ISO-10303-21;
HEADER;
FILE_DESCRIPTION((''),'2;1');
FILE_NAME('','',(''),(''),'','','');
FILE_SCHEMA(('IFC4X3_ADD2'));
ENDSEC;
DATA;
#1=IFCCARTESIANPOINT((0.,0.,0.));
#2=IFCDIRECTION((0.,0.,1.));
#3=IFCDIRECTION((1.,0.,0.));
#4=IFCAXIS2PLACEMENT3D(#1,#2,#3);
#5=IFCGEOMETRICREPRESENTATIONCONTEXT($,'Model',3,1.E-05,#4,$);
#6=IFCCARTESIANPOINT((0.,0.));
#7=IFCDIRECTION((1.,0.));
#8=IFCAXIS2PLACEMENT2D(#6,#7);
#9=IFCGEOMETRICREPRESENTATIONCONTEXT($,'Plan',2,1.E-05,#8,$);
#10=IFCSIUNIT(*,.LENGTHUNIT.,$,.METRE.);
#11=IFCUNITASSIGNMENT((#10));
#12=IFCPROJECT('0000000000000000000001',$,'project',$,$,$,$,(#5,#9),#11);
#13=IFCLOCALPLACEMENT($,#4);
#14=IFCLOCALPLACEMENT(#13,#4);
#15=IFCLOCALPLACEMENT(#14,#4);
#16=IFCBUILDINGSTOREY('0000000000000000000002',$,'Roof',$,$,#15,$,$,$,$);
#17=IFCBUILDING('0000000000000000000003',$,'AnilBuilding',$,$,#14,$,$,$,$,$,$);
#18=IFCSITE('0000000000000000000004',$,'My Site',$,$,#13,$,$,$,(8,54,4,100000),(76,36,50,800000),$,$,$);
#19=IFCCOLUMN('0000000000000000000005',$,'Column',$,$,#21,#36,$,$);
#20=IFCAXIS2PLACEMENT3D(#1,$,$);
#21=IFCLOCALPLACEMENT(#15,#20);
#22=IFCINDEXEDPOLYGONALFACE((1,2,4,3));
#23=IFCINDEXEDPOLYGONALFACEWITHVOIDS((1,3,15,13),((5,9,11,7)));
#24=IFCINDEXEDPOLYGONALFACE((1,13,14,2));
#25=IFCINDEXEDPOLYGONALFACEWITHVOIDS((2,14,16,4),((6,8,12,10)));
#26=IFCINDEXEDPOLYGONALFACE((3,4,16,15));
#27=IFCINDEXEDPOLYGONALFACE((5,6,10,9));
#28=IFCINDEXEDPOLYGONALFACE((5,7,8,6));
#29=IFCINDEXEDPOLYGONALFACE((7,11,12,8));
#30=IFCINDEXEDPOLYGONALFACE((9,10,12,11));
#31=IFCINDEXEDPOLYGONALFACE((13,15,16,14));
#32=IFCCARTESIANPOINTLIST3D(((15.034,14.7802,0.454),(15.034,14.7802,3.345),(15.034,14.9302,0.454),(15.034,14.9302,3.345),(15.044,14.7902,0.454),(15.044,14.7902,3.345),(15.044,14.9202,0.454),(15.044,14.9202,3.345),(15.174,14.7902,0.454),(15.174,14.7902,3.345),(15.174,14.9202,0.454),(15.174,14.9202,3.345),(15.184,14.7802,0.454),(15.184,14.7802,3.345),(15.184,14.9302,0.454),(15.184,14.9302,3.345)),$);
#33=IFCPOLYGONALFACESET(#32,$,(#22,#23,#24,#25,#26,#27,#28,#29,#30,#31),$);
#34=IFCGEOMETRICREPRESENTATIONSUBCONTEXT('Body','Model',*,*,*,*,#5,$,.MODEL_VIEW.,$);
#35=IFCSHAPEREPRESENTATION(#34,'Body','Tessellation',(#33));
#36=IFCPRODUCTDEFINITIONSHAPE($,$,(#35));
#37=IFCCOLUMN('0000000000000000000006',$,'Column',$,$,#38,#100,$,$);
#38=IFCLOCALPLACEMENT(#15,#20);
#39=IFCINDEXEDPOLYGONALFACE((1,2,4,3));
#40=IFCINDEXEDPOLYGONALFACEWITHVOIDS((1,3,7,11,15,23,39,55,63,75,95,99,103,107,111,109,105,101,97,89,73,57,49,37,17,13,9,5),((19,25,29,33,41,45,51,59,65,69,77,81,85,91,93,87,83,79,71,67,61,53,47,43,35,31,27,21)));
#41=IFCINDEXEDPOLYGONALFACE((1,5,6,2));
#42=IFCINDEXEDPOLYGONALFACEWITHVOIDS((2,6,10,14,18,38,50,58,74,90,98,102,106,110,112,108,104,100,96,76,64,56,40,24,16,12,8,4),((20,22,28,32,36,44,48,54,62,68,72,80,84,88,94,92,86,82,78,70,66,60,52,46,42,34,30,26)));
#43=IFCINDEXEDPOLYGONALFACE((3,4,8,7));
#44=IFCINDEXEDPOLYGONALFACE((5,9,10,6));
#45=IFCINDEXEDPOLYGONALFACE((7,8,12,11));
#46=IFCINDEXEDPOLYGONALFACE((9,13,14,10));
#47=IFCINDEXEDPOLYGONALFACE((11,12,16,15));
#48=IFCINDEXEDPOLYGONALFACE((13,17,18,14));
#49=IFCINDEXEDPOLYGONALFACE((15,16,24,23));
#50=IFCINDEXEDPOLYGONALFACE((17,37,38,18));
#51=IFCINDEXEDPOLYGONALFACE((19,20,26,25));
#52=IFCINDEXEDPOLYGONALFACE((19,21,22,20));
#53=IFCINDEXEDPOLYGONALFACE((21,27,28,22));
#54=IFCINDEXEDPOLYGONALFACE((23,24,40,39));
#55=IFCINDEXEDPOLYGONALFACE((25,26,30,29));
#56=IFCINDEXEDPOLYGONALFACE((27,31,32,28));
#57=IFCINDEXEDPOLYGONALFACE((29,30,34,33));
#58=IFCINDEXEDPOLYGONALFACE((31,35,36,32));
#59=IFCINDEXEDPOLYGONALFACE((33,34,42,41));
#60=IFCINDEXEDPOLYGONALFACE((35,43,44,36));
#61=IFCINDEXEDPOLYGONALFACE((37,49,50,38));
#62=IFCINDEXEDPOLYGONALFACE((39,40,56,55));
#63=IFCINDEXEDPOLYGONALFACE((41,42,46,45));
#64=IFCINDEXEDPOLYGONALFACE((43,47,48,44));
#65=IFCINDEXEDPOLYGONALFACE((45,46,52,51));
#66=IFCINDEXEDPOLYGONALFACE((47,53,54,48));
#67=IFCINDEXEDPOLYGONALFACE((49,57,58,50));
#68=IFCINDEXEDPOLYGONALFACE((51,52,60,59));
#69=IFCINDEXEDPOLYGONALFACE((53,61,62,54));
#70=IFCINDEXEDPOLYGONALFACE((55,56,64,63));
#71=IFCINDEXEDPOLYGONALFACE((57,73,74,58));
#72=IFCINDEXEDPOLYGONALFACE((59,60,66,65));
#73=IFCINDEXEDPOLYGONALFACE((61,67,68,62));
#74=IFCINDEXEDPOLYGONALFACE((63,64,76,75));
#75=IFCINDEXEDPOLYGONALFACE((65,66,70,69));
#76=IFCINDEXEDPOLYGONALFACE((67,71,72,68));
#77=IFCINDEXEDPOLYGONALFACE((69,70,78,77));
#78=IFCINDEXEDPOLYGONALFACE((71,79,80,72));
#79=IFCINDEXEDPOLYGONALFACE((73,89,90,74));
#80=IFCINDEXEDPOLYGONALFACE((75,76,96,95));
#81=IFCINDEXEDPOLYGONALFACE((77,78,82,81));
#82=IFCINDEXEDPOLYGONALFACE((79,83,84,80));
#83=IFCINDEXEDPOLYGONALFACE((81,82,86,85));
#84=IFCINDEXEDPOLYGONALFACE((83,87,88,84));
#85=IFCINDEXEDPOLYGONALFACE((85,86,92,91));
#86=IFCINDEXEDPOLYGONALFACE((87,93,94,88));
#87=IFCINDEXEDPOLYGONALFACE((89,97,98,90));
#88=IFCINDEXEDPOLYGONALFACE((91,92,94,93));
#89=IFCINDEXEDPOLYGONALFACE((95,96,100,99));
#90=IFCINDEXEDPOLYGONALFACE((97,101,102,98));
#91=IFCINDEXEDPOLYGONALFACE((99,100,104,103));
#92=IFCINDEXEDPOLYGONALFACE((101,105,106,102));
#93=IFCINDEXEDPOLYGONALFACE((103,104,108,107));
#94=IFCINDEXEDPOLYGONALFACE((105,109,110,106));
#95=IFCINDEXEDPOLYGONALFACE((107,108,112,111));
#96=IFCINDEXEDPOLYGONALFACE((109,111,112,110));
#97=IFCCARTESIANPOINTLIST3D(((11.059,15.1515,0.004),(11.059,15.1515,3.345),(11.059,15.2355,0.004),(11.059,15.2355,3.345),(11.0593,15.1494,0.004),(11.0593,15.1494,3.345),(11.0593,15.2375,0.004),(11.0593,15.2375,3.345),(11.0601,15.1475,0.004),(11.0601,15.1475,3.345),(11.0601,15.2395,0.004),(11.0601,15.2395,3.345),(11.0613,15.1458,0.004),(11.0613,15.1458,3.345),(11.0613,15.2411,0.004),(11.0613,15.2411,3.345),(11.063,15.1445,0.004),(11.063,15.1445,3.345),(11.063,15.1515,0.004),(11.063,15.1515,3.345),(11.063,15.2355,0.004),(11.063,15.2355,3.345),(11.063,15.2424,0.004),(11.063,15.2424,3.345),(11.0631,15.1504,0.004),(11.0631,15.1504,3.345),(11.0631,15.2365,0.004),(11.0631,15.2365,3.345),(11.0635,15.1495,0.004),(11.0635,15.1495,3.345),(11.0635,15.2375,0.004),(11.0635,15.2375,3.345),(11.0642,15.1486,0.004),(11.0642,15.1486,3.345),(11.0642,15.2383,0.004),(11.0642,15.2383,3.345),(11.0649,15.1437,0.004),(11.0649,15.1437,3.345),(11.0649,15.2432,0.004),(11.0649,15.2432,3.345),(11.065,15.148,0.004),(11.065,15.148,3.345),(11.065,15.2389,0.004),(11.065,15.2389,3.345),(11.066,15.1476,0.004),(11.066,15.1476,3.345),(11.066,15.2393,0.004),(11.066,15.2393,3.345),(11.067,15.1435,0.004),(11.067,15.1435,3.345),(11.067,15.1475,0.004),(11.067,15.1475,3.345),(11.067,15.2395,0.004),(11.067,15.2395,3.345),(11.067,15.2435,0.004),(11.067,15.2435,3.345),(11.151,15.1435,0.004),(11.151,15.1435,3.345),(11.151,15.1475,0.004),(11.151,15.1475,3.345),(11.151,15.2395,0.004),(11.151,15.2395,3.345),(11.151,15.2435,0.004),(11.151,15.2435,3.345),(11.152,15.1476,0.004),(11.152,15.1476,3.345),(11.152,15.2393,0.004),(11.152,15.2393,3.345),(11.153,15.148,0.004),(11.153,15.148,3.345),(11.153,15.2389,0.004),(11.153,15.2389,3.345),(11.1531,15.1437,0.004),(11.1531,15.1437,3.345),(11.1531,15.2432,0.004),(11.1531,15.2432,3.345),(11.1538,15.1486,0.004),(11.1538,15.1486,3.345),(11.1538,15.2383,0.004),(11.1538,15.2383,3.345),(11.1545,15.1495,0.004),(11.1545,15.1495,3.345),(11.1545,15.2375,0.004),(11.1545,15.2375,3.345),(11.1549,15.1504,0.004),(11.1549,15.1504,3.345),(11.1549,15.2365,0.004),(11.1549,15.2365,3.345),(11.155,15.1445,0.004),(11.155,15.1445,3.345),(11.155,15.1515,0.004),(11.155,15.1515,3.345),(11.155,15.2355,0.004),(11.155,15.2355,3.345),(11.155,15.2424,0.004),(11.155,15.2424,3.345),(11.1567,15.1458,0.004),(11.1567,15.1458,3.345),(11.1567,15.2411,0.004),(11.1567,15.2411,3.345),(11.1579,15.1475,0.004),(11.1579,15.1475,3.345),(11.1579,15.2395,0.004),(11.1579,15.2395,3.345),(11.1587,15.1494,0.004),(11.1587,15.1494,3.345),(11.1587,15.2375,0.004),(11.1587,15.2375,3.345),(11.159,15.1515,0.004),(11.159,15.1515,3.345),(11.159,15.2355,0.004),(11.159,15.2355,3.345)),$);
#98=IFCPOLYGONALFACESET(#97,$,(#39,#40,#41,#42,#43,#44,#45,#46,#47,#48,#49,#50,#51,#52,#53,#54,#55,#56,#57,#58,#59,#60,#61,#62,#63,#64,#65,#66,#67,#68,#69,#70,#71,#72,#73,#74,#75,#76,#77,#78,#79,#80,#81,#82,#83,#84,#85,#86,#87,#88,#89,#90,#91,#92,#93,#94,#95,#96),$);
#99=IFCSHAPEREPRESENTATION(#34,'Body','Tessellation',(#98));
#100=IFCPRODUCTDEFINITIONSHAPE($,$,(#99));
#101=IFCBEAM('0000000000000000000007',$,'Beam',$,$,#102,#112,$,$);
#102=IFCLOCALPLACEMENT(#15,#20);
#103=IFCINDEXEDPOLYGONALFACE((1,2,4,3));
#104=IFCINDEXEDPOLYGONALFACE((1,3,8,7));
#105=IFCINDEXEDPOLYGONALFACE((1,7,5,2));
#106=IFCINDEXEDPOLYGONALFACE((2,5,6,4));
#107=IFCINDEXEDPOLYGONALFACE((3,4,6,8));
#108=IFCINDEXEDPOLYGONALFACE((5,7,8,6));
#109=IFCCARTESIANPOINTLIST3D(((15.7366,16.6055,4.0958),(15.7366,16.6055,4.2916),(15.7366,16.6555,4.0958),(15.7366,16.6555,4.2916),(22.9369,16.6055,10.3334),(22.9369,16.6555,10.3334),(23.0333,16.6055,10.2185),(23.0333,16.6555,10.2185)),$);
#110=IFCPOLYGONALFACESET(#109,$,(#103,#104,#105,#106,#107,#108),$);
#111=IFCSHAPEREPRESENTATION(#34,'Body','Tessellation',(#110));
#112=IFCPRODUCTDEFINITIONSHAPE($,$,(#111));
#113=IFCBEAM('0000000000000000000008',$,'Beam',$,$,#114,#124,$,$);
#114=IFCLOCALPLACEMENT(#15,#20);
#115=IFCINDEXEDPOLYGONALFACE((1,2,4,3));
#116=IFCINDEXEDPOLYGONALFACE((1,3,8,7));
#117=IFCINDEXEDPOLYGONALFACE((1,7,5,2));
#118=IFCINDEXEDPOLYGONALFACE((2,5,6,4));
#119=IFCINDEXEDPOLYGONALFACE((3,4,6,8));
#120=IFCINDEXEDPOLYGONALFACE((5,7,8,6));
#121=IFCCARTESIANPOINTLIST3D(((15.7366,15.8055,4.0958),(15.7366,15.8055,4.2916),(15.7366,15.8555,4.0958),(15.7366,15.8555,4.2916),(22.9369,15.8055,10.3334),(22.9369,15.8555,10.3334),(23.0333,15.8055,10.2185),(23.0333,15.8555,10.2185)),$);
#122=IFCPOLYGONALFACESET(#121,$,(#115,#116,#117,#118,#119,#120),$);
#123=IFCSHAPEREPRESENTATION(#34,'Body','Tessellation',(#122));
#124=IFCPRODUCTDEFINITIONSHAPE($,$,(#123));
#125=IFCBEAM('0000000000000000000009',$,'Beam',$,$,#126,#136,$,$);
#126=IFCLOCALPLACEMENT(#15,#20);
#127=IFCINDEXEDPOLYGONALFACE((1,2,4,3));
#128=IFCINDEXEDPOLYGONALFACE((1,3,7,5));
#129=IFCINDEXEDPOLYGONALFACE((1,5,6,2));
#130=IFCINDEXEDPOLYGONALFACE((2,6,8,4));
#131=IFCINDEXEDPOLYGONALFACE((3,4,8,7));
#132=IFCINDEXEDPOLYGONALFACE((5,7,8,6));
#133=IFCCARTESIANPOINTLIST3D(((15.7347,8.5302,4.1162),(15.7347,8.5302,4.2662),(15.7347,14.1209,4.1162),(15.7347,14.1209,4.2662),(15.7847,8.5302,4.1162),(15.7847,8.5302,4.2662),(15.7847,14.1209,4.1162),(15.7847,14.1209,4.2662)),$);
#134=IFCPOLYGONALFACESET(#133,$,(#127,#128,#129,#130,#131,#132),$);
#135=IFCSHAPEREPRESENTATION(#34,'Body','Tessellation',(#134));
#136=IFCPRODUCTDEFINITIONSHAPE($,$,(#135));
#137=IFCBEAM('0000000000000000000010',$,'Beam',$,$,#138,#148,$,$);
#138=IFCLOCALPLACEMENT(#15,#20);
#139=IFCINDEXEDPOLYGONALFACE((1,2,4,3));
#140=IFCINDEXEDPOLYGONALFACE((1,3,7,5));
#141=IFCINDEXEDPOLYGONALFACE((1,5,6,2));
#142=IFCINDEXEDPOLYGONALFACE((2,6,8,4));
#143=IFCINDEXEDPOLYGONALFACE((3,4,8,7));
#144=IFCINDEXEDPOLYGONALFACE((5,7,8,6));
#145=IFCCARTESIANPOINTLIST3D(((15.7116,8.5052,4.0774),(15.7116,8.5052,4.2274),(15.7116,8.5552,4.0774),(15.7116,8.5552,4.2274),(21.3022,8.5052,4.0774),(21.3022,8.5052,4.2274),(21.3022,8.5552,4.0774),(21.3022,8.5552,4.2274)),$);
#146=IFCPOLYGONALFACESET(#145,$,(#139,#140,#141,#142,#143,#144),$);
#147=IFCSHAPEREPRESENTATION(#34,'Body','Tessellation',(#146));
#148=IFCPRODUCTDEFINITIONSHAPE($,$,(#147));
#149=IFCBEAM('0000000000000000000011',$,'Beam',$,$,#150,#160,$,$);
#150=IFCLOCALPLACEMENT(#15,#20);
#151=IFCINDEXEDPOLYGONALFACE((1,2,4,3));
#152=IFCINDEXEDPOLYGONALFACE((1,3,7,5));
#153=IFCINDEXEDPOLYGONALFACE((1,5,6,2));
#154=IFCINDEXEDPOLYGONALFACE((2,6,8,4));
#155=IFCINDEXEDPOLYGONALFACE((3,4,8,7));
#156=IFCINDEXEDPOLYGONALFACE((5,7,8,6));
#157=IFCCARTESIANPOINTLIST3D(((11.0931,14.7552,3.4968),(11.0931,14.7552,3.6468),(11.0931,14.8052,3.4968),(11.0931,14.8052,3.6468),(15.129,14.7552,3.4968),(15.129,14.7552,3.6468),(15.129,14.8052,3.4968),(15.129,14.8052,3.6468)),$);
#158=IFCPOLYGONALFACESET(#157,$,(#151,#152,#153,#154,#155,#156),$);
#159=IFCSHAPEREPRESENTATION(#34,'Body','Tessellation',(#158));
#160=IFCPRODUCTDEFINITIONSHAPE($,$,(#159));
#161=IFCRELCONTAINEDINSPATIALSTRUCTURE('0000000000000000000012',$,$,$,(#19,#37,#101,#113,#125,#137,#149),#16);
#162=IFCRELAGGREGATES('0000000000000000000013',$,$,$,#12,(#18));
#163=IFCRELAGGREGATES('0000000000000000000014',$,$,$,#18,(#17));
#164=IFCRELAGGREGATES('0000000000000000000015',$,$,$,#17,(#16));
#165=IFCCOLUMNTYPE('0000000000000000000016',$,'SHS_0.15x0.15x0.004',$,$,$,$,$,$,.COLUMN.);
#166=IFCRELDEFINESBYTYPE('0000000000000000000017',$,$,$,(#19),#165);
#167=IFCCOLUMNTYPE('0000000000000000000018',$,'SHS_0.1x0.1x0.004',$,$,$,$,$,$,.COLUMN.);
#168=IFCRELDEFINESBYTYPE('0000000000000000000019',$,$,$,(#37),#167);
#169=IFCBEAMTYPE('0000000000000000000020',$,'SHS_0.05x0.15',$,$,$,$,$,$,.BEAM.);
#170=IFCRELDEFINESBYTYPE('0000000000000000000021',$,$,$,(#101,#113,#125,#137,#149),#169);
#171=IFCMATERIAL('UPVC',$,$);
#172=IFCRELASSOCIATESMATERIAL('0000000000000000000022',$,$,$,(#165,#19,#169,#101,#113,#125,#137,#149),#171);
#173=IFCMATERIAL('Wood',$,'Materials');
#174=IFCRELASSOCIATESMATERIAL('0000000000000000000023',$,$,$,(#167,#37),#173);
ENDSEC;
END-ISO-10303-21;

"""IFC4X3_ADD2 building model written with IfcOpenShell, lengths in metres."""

from ifc_helpers import new_model, entity, si_unit, frame, origin_with_axes, origin_2d_with_axis, place, context, subcontext, project, spatial, indexed_curve, hollow_rectangle, outline, extrude, clip, halfspace, shape, material, material_profile, profile_set, profile_usage, type_object, element, save


model = new_model("IFC4X3_ADD2")

# Units and contexts
model_context = context("Model", 3, precision=1e-05, world=origin_with_axes())
plan_context = context("Plan", 2, precision=1e-05, world=origin_2d_with_axis())
body_context_1 = subcontext(model_context, "Body", "Model", "MODEL_VIEW")
body_context_2 = subcontext(plan_context, "Body", "Plan", "PLAN_VIEW")
ifc_project = project(units=[si_unit("LENGTHUNIT", "METRE")], contexts=[model_context, plan_context])

# Site, building, storey
site_placement = place(None, origin_with_axes())
site = spatial("IfcSite", under=ifc_project, at=site_placement, Name="My Site", RefLatitude=(8, 54, 4, 100000), RefLongitude=(76, 36, 50, 800000))
building_placement = place(site_placement, origin_with_axes())
building = spatial("IfcBuilding", under=site, at=building_placement, Name="AnilBuilding")
storey_placement = place(building_placement, origin_with_axes())
storey = spatial("IfcBuildingStorey", under=building, at=storey_placement, Name="Roof")

# Columns
ifc_material_1 = material(Name="UPVC")
ifc_material_profile_1 = material_profile(ifc_material_1, hollow_rectangle(XDim=0.15, YDim=0.15, WallThickness=0.01))
ifc_profile_set_1 = profile_set([ifc_material_profile_1])
ifc_profile_usage_1 = profile_usage(ifc_profile_set_1)
column_type_1 = type_object("IfcColumnType", Name="SHS_0.15x0.15x0.004", PredefinedType="COLUMN", material=ifc_profile_set_1)
column_1_placement = place(storey_placement, frame((15.109, 14.8552, 0.454), z_axis=(0.0, 0.0, 1.0), x_axis=(1.0, 0.0, 0.0)))
element("IfcColumn", 1, at=column_1_placement, inside=storey, type_object=column_type_1, material=ifc_profile_usage_1, Name="Column", shapes=[
    shape(body_context_1, "Body", "SweptSolid", [extrude(hollow_rectangle(XDim=0.15, YDim=0.15, WallThickness=0.01), origin_with_axes(), (0.0, 0.0, 1.0), 2.891)]),
    shape(body_context_2, "Body", "Annotation2D", [entity("IfcGeometricCurveSet", [entity("IfcIndexedPolyCurve", entity("IfcCartesianPointList2D", [[0.065, 0.065], [0.065, -0.065], [-0.065, -0.065], [-0.065, 0.065]]), [entity("IfcLineIndex", [1, 2, 3, 4, 1])]), entity("IfcIndexedPolyCurve", entity("IfcCartesianPointList2D", [[-0.075, -0.075], [0.075, -0.075], [0.075, 0.075], [-0.075, 0.075]]), [entity("IfcLineIndex", [1, 2, 3, 4, 1])])])]),
])
ifc_material_2 = material(Name="Wood", Category="Materials")
ifc_material_profile_2 = material_profile(ifc_material_2, hollow_rectangle(XDim=0.1, YDim=0.1, WallThickness=0.004, InnerFilletRadius=0.004, OuterFilletRadius=0.008))
ifc_profile_set_2 = profile_set([ifc_material_profile_2])
column_type_2 = type_object("IfcColumnType", Name="SHS_0.1x0.1x0.004", PredefinedType="COLUMN", material=ifc_profile_set_2)
ifc_profile_usage_2 = profile_usage(ifc_profile_set_2)
column_2_placement = place(storey_placement, frame((11.109, 15.1935, 0.004), z_axis=(0.0, 0.0, 1.0), x_axis=(1.0, 0.0, 0.0)))
element("IfcColumn", 2, at=column_2_placement, inside=storey, type_object=column_type_2, material=ifc_profile_usage_2, Name="Column", shapes=[
    shape(body_context_1, "Body", "SweptSolid", [extrude(hollow_rectangle(XDim=0.1, YDim=0.1, WallThickness=0.004, InnerFilletRadius=0.004, OuterFilletRadius=0.008), origin_with_axes(), (0.0, 0.0, 1.0), 3.341)]),
    shape(body_context_2, "Body", "Annotation2D", [entity("IfcGeometricCurveSet", [entity("IfcIndexedPolyCurve", entity("IfcCartesianPointList2D", [[-0.065, -0.065], [0.065, -0.065], [0.065, 0.065], [-0.065, 0.065]]), [entity("IfcLineIndex", [1, 2, 3, 4, 1])]), entity("IfcIndexedPolyCurve", entity("IfcCartesianPointList2D", [[0.075, -0.075], [-0.075, -0.075], [-0.075, 0.075], [0.075, 0.075]]), [entity("IfcLineIndex", [1, 2, 3, 4, 1])])])]),
])

# Beams
ifc_material_profile_3 = material_profile(ifc_material_1, outline(indexed_curve([(-0.025, 0.075), (0.025, 0.075), (0.025, -0.075), (-0.025, -0.075), (-0.025, 0.075)])))
ifc_profile_set_3 = profile_set([ifc_material_profile_3])
ifc_profile_usage_3 = profile_usage(ifc_profile_set_3, cardinal=5)
beam_type = type_object("IfcBeamType", Name="SHS_0.05x0.15", PredefinedType="BEAM", material=ifc_profile_set_3)
beam_1_placement = place(storey_placement, frame((15.6217, 16.6305, 4.0973), z_axis=(0.766044, 0.0, 0.642788), x_axis=(0.000001, 1.0, 0.0)))
element("IfcBeam", 3, at=beam_1_placement, inside=storey, type_object=beam_type, material=ifc_profile_usage_3, Name="Beam", context=body_context_1, shape_type="Clipping", body=[
    clip(extrude(outline(indexed_curve([(-0.025, 0.075), (0.025, 0.075), (0.025, -0.075), (-0.025, -0.075), (-0.025, 0.075)])), origin_with_axes(), (0.0, 0.0, 1.0), 9.6123), halfspace(frame((-8.1003, -0.0316, 0.1235), z_axis=(0.0, 0.642788, -0.766044), x_axis=(1.0, 0.0, 0.0)), False)),
])
ifc_profile_usage_4 = profile_usage(ifc_profile_set_3, cardinal=5)
beam_2_placement = place(storey_placement, frame((15.6217, 15.8305, 4.0973), z_axis=(0.766044, 0.0, 0.642788), x_axis=(0.000001, 1.0, 0.0)))
element("IfcBeam", 4, at=beam_2_placement, inside=storey, type_object=beam_type, material=ifc_profile_usage_4, Name="Beam", context=body_context_1, shape_type="Clipping", body=[
    clip(extrude(outline(indexed_curve([(-0.025, 0.075), (0.025, 0.075), (0.025, -0.075), (-0.025, -0.075), (-0.025, 0.075)])), origin_with_axes(), (0.0, 0.0, 1.0), 9.6123), halfspace(frame((-7.3003, -0.0316, 0.1235), z_axis=(0.0, 0.642788, -0.766044), x_axis=(1.0, 0.0, 0.0)), False)),
])
ifc_profile_usage_5 = profile_usage(ifc_profile_set_3, cardinal=5)
beam_3_placement = place(storey_placement, frame((15.7597, 8.5302, 4.1912), z_axis=(0.000001, 1.0, 0.0), x_axis=(-1.0, 0.000001, 0.0)))
element("IfcBeam", 5, at=beam_3_placement, inside=storey, type_object=beam_type, material=ifc_profile_usage_5, Name="Beam", context=body_context_1, shape_type="SweptSolid", body=[
    extrude(outline(indexed_curve([(-0.025, 0.075), (0.025, 0.075), (0.025, -0.075), (-0.025, -0.075), (-0.025, 0.075)])), origin_with_axes(), (0.0, 0.0, 1.0), 5.5906),
])
ifc_profile_usage_6 = profile_usage(ifc_profile_set_3, cardinal=5)
beam_4_placement = place(storey_placement, frame((15.7116, 8.5302, 4.1524), z_axis=(1.0, -0.000002, 0.0), x_axis=(0.000002, 1.0, 0.0)))
element("IfcBeam", 6, at=beam_4_placement, inside=storey, type_object=beam_type, material=ifc_profile_usage_6, Name="Beam", context=body_context_1, shape_type="SweptSolid", body=[
    extrude(outline(indexed_curve([(-0.025, 0.075), (0.025, 0.075), (0.025, -0.075), (-0.025, -0.075), (-0.025, 0.075)])), origin_with_axes(), (0.0, 0.0, 1.0), 5.5906),
])
ifc_profile_usage_7 = profile_usage(ifc_profile_set_3, cardinal=5)
beam_5_placement = place(storey_placement, frame((15.129, 14.7802, 3.5718), z_axis=(-1.0, 0.000001, 0.0), x_axis=(-0.000001, -1.0, 0.0)))
element("IfcBeam", 7, at=beam_5_placement, inside=storey, type_object=beam_type, material=ifc_profile_usage_7, Name="Beam", context=body_context_1, shape_type="SweptSolid", body=[
    extrude(outline(indexed_curve([(-0.025, 0.075), (0.025, 0.075), (0.025, -0.075), (-0.025, -0.075), (-0.025, 0.075)])), origin_with_axes(), (0.0, 0.0, 1.0), 4.0359),
])

save(model, "model.ifc")
